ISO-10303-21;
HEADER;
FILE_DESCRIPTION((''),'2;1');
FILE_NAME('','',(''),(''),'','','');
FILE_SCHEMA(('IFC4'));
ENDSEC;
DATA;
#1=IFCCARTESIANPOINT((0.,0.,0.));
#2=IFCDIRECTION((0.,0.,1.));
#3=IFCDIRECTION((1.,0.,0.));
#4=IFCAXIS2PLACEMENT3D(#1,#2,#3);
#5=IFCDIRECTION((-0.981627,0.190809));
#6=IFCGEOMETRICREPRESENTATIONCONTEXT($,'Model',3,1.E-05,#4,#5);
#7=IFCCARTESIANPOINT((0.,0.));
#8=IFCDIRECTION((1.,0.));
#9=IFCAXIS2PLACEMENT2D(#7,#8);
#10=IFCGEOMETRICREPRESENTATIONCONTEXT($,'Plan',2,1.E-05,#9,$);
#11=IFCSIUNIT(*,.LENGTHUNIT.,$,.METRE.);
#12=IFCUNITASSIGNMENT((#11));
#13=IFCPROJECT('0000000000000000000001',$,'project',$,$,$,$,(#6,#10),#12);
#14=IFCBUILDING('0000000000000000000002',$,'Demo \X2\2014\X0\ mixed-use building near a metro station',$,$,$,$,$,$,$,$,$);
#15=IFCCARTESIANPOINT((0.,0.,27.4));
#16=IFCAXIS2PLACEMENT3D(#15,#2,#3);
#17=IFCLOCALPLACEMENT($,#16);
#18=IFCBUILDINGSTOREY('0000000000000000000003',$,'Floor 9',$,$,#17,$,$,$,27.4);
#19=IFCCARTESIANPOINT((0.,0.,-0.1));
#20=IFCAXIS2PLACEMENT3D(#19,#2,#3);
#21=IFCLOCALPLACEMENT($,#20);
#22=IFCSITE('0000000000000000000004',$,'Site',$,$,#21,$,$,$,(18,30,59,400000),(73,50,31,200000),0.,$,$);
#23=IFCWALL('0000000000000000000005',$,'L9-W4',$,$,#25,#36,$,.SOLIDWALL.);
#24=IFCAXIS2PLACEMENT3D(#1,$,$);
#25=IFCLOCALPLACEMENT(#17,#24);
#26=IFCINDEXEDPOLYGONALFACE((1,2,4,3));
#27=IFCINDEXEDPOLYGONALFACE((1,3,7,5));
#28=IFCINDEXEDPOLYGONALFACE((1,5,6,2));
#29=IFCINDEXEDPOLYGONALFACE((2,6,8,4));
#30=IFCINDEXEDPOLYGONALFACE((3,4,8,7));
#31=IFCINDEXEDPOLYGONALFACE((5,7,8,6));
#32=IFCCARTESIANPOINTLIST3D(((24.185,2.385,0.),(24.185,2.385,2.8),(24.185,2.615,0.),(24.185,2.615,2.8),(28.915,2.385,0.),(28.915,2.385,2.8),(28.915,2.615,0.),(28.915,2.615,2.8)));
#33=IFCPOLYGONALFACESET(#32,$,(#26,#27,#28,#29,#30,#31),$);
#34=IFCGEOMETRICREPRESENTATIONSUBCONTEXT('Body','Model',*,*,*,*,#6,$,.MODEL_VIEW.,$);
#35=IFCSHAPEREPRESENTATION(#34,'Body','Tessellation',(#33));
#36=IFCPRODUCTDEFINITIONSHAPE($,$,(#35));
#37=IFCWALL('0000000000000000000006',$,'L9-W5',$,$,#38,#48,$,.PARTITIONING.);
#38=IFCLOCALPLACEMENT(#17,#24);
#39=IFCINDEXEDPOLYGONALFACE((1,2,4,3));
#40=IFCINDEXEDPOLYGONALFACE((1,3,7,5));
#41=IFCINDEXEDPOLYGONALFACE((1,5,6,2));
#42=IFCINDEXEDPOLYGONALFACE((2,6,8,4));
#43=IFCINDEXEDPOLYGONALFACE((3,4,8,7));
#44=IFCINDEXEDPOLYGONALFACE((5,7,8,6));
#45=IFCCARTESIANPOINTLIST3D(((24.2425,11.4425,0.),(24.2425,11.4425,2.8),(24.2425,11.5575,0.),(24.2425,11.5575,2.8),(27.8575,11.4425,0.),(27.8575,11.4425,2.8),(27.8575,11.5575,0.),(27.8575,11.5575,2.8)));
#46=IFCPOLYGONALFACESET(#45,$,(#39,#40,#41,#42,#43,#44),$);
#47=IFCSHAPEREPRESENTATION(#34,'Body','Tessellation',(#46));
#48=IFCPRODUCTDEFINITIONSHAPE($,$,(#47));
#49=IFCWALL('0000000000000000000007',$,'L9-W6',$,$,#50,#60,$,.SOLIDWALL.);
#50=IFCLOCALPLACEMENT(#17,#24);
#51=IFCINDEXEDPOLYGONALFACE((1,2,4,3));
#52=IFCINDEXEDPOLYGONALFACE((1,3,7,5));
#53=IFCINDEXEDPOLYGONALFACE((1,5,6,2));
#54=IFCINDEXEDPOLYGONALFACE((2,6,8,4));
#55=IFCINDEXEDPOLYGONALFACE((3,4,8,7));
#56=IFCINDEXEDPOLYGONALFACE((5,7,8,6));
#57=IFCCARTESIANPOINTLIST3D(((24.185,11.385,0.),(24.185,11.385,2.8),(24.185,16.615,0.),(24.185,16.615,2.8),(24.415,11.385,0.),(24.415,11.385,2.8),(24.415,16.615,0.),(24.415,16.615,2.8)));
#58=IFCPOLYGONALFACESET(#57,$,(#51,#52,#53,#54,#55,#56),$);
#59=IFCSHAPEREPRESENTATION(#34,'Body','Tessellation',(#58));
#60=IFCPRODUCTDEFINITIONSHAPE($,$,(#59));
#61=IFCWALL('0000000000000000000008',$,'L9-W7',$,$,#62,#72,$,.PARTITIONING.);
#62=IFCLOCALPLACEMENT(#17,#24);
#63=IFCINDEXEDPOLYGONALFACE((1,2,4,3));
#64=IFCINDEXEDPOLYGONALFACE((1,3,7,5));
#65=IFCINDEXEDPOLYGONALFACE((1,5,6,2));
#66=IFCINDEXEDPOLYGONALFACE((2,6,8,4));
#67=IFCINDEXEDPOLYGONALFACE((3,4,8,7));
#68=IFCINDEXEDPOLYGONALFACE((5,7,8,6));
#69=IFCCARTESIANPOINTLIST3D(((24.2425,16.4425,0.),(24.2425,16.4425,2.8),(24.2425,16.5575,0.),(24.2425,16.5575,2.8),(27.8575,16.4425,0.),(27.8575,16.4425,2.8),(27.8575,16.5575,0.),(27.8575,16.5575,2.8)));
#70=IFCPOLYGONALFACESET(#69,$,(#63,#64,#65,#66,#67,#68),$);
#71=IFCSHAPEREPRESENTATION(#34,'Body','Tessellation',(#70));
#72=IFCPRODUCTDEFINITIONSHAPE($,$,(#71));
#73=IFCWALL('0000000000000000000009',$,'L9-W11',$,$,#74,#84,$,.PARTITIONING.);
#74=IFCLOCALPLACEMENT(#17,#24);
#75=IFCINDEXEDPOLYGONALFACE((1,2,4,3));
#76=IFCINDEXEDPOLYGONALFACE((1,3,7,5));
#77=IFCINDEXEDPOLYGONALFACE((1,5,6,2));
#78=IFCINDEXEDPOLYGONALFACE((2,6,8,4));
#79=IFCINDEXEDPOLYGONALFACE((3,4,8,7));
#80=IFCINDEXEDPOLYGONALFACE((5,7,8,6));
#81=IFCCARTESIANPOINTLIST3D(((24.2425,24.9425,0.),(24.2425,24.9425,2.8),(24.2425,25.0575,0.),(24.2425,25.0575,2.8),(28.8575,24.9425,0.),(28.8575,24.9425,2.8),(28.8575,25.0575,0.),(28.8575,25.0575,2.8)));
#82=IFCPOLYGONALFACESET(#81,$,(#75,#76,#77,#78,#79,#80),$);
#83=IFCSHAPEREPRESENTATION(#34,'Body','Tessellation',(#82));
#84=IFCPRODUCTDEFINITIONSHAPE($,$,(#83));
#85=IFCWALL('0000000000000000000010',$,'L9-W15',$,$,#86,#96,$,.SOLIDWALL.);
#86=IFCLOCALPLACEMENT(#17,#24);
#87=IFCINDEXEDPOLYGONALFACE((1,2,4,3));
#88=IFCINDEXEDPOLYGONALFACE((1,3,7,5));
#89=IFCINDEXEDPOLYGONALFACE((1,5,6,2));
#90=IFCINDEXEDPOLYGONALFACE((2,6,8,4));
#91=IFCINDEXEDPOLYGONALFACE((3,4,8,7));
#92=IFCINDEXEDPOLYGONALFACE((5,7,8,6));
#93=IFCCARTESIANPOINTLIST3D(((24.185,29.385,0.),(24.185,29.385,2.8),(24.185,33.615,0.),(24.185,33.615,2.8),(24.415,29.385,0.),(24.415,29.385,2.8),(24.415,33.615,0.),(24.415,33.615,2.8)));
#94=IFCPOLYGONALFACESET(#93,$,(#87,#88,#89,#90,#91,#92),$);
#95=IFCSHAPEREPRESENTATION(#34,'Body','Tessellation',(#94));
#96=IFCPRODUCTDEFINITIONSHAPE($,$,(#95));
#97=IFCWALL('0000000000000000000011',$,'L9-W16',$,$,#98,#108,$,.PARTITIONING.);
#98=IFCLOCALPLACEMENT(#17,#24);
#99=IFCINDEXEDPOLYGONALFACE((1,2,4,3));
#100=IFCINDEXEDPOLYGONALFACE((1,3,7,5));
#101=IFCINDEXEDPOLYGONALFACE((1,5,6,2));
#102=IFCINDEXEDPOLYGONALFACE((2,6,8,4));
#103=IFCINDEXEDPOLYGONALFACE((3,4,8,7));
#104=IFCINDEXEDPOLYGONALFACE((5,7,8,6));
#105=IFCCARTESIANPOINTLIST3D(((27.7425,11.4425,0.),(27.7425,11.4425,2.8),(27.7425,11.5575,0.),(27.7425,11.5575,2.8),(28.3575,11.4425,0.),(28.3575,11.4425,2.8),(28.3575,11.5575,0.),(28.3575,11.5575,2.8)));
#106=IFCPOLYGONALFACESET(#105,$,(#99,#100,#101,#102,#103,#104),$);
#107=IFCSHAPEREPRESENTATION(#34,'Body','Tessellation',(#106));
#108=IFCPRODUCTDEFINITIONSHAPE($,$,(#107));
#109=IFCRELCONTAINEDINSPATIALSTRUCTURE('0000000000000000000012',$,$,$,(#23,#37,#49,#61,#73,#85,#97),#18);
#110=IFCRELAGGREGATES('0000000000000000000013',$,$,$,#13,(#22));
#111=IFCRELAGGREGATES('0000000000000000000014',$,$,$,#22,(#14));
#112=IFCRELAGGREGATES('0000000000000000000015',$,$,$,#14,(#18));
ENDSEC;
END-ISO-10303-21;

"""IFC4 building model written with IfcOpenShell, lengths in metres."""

from ifc_helpers import new_model, si_unit, direction, frame, origin_with_axes, origin_2d_with_axis, place, context, subcontext, project, spatial, line, indexed_curve, outline, extrude, element, save


model = new_model("IFC4")

# Units and contexts
model_context = context("Model", 3, precision=1e-05, world=origin_with_axes(), true_north=direction((-0.981627, 0.190809)))
plan_context = context("Plan", 2, precision=1e-05, world=origin_2d_with_axis())
body_context = subcontext(model_context, "Body", "Model", "MODEL_VIEW")
ifc_project = project(units=[si_unit("LENGTHUNIT", "METRE")], contexts=[model_context, plan_context])

# Site, building, storey
site_placement = place(None, frame((0.0, 0.0, -0.1), z_axis=(0.0, 0.0, 1.0), x_axis=(1.0, 0.0, 0.0)))
site = spatial("IfcSite", under=ifc_project, at=site_placement, Name="Site", RefLatitude=(18, 30, 59, 400000), RefLongitude=(73, 50, 31, 200000), RefElevation=0.0)
building = spatial("IfcBuilding", under=site, Name="Demo — mixed-use building near a metro station")
storey_placement = place(None, frame((0.0, 0.0, 27.4), z_axis=(0.0, 0.0, 1.0), x_axis=(1.0, 0.0, 0.0)))
storey = spatial("IfcBuildingStorey", under=building, at=storey_placement, Name="Floor 9", Elevation=27.4)

# Walls
wall_1_placement = place(storey_placement, frame((0.0, 0.0, -27.4), z_axis=(0.0, 0.0, 1.0), x_axis=(1.0, 0.0, 0.0)))
element("IfcWall", 1, at=wall_1_placement, inside=storey, Name="L9-W4", PredefinedType="SOLIDWALL", context=body_context, shape_type="SweptSolid", body=[
    extrude(outline(indexed_curve([(24.185, 2.615), (28.915, 2.615), (28.915, 2.385), (24.185, 2.385)], segments=[line(1, 2, 3, 4, 1)])), frame((0.0, 0.0, 27.4), z_axis=(0.0, 0.0, 1.0), x_axis=(1.0, 0.0, 0.0)), (0.0, 0.0, 1.0), 2.8),
])
wall_2_placement = place(storey_placement, frame((0.0, 0.0, -27.4), z_axis=(0.0, 0.0, 1.0), x_axis=(1.0, 0.0, 0.0)))
element("IfcWall", 2, at=wall_2_placement, inside=storey, Name="L9-W5", PredefinedType="PARTITIONING", context=body_context, shape_type="SweptSolid", body=[
    extrude(outline(indexed_curve([(24.2425, 11.5575), (27.8575, 11.5575), (27.8575, 11.4425), (24.2425, 11.4425)], segments=[line(1, 2, 3, 4, 1)])), frame((0.0, 0.0, 27.4), z_axis=(0.0, 0.0, 1.0), x_axis=(1.0, 0.0, 0.0)), (0.0, 0.0, 1.0), 2.8),
])
wall_3_placement = place(storey_placement, frame((0.0, 0.0, -27.4), z_axis=(0.0, 0.0, 1.0), x_axis=(1.0, 0.0, 0.0)))
element("IfcWall", 3, at=wall_3_placement, inside=storey, Name="L9-W6", PredefinedType="SOLIDWALL", context=body_context, shape_type="SweptSolid", body=[
    extrude(outline(indexed_curve([(24.415, 16.615), (24.415, 11.385), (24.185, 11.385), (24.185, 16.615)], segments=[line(1, 2, 3, 4, 1)])), frame((0.0, 0.0, 27.4), z_axis=(0.0, 0.0, 1.0), x_axis=(1.0, 0.0, 0.0)), (0.0, 0.0, 1.0), 2.8),
])
wall_4_placement = place(storey_placement, frame((0.0, 0.0, -27.4), z_axis=(0.0, 0.0, 1.0), x_axis=(1.0, 0.0, 0.0)))
element("IfcWall", 4, at=wall_4_placement, inside=storey, Name="L9-W7", PredefinedType="PARTITIONING", context=body_context, shape_type="SweptSolid", body=[
    extrude(outline(indexed_curve([(27.8575, 16.4425), (24.2425, 16.4425), (24.2425, 16.5575), (27.8575, 16.5575)], segments=[line(1, 2, 3, 4, 1)])), frame((0.0, 0.0, 27.4), z_axis=(0.0, 0.0, 1.0), x_axis=(1.0, 0.0, 0.0)), (0.0, 0.0, 1.0), 2.8),
])

# Wall
wall_5_placement = place(storey_placement, frame((0.0, 0.0, -27.4), z_axis=(0.0, 0.0, 1.0), x_axis=(1.0, 0.0, 0.0)))
element("IfcWall", 5, at=wall_5_placement, inside=storey, Name="L9-W11", PredefinedType="PARTITIONING", context=body_context, shape_type="SweptSolid", body=[
    extrude(outline(indexed_curve([(28.8575, 24.9425), (24.2425, 24.9425), (24.2425, 25.0575), (28.8575, 25.0575)], segments=[line(1, 2, 3, 4, 1)])), frame((0.0, 0.0, 27.4), z_axis=(0.0, 0.0, 1.0), x_axis=(1.0, 0.0, 0.0)), (0.0, 0.0, 1.0), 2.8),
])

# Walls
wall_6_placement = place(storey_placement, frame((0.0, 0.0, -27.4), z_axis=(0.0, 0.0, 1.0), x_axis=(1.0, 0.0, 0.0)))
element("IfcWall", 6, at=wall_6_placement, inside=storey, Name="L9-W15", PredefinedType="SOLIDWALL", context=body_context, shape_type="SweptSolid", body=[
    extrude(outline(indexed_curve([(24.415, 33.615), (24.415, 29.385), (24.185, 29.385), (24.185, 33.615)], segments=[line(1, 2, 3, 4, 1)])), frame((0.0, 0.0, 27.4), z_axis=(0.0, 0.0, 1.0), x_axis=(1.0, 0.0, 0.0)), (0.0, 0.0, 1.0), 2.8),
])
wall_7_placement = place(storey_placement, frame((0.0, 0.0, -27.4), z_axis=(0.0, 0.0, 1.0), x_axis=(1.0, 0.0, 0.0)))
element("IfcWall", 7, at=wall_7_placement, inside=storey, Name="L9-W16", PredefinedType="PARTITIONING", context=body_context, shape_type="SweptSolid", body=[
    extrude(outline(indexed_curve([(27.7425, 11.5575), (28.3575, 11.5575), (28.3575, 11.4425), (27.7425, 11.4425)], segments=[line(1, 2, 3, 4, 1)])), frame((0.0, 0.0, 27.4), z_axis=(0.0, 0.0, 1.0), x_axis=(1.0, 0.0, 0.0)), (0.0, 0.0, 1.0), 2.8),
])

save(model, "model.ifc")
